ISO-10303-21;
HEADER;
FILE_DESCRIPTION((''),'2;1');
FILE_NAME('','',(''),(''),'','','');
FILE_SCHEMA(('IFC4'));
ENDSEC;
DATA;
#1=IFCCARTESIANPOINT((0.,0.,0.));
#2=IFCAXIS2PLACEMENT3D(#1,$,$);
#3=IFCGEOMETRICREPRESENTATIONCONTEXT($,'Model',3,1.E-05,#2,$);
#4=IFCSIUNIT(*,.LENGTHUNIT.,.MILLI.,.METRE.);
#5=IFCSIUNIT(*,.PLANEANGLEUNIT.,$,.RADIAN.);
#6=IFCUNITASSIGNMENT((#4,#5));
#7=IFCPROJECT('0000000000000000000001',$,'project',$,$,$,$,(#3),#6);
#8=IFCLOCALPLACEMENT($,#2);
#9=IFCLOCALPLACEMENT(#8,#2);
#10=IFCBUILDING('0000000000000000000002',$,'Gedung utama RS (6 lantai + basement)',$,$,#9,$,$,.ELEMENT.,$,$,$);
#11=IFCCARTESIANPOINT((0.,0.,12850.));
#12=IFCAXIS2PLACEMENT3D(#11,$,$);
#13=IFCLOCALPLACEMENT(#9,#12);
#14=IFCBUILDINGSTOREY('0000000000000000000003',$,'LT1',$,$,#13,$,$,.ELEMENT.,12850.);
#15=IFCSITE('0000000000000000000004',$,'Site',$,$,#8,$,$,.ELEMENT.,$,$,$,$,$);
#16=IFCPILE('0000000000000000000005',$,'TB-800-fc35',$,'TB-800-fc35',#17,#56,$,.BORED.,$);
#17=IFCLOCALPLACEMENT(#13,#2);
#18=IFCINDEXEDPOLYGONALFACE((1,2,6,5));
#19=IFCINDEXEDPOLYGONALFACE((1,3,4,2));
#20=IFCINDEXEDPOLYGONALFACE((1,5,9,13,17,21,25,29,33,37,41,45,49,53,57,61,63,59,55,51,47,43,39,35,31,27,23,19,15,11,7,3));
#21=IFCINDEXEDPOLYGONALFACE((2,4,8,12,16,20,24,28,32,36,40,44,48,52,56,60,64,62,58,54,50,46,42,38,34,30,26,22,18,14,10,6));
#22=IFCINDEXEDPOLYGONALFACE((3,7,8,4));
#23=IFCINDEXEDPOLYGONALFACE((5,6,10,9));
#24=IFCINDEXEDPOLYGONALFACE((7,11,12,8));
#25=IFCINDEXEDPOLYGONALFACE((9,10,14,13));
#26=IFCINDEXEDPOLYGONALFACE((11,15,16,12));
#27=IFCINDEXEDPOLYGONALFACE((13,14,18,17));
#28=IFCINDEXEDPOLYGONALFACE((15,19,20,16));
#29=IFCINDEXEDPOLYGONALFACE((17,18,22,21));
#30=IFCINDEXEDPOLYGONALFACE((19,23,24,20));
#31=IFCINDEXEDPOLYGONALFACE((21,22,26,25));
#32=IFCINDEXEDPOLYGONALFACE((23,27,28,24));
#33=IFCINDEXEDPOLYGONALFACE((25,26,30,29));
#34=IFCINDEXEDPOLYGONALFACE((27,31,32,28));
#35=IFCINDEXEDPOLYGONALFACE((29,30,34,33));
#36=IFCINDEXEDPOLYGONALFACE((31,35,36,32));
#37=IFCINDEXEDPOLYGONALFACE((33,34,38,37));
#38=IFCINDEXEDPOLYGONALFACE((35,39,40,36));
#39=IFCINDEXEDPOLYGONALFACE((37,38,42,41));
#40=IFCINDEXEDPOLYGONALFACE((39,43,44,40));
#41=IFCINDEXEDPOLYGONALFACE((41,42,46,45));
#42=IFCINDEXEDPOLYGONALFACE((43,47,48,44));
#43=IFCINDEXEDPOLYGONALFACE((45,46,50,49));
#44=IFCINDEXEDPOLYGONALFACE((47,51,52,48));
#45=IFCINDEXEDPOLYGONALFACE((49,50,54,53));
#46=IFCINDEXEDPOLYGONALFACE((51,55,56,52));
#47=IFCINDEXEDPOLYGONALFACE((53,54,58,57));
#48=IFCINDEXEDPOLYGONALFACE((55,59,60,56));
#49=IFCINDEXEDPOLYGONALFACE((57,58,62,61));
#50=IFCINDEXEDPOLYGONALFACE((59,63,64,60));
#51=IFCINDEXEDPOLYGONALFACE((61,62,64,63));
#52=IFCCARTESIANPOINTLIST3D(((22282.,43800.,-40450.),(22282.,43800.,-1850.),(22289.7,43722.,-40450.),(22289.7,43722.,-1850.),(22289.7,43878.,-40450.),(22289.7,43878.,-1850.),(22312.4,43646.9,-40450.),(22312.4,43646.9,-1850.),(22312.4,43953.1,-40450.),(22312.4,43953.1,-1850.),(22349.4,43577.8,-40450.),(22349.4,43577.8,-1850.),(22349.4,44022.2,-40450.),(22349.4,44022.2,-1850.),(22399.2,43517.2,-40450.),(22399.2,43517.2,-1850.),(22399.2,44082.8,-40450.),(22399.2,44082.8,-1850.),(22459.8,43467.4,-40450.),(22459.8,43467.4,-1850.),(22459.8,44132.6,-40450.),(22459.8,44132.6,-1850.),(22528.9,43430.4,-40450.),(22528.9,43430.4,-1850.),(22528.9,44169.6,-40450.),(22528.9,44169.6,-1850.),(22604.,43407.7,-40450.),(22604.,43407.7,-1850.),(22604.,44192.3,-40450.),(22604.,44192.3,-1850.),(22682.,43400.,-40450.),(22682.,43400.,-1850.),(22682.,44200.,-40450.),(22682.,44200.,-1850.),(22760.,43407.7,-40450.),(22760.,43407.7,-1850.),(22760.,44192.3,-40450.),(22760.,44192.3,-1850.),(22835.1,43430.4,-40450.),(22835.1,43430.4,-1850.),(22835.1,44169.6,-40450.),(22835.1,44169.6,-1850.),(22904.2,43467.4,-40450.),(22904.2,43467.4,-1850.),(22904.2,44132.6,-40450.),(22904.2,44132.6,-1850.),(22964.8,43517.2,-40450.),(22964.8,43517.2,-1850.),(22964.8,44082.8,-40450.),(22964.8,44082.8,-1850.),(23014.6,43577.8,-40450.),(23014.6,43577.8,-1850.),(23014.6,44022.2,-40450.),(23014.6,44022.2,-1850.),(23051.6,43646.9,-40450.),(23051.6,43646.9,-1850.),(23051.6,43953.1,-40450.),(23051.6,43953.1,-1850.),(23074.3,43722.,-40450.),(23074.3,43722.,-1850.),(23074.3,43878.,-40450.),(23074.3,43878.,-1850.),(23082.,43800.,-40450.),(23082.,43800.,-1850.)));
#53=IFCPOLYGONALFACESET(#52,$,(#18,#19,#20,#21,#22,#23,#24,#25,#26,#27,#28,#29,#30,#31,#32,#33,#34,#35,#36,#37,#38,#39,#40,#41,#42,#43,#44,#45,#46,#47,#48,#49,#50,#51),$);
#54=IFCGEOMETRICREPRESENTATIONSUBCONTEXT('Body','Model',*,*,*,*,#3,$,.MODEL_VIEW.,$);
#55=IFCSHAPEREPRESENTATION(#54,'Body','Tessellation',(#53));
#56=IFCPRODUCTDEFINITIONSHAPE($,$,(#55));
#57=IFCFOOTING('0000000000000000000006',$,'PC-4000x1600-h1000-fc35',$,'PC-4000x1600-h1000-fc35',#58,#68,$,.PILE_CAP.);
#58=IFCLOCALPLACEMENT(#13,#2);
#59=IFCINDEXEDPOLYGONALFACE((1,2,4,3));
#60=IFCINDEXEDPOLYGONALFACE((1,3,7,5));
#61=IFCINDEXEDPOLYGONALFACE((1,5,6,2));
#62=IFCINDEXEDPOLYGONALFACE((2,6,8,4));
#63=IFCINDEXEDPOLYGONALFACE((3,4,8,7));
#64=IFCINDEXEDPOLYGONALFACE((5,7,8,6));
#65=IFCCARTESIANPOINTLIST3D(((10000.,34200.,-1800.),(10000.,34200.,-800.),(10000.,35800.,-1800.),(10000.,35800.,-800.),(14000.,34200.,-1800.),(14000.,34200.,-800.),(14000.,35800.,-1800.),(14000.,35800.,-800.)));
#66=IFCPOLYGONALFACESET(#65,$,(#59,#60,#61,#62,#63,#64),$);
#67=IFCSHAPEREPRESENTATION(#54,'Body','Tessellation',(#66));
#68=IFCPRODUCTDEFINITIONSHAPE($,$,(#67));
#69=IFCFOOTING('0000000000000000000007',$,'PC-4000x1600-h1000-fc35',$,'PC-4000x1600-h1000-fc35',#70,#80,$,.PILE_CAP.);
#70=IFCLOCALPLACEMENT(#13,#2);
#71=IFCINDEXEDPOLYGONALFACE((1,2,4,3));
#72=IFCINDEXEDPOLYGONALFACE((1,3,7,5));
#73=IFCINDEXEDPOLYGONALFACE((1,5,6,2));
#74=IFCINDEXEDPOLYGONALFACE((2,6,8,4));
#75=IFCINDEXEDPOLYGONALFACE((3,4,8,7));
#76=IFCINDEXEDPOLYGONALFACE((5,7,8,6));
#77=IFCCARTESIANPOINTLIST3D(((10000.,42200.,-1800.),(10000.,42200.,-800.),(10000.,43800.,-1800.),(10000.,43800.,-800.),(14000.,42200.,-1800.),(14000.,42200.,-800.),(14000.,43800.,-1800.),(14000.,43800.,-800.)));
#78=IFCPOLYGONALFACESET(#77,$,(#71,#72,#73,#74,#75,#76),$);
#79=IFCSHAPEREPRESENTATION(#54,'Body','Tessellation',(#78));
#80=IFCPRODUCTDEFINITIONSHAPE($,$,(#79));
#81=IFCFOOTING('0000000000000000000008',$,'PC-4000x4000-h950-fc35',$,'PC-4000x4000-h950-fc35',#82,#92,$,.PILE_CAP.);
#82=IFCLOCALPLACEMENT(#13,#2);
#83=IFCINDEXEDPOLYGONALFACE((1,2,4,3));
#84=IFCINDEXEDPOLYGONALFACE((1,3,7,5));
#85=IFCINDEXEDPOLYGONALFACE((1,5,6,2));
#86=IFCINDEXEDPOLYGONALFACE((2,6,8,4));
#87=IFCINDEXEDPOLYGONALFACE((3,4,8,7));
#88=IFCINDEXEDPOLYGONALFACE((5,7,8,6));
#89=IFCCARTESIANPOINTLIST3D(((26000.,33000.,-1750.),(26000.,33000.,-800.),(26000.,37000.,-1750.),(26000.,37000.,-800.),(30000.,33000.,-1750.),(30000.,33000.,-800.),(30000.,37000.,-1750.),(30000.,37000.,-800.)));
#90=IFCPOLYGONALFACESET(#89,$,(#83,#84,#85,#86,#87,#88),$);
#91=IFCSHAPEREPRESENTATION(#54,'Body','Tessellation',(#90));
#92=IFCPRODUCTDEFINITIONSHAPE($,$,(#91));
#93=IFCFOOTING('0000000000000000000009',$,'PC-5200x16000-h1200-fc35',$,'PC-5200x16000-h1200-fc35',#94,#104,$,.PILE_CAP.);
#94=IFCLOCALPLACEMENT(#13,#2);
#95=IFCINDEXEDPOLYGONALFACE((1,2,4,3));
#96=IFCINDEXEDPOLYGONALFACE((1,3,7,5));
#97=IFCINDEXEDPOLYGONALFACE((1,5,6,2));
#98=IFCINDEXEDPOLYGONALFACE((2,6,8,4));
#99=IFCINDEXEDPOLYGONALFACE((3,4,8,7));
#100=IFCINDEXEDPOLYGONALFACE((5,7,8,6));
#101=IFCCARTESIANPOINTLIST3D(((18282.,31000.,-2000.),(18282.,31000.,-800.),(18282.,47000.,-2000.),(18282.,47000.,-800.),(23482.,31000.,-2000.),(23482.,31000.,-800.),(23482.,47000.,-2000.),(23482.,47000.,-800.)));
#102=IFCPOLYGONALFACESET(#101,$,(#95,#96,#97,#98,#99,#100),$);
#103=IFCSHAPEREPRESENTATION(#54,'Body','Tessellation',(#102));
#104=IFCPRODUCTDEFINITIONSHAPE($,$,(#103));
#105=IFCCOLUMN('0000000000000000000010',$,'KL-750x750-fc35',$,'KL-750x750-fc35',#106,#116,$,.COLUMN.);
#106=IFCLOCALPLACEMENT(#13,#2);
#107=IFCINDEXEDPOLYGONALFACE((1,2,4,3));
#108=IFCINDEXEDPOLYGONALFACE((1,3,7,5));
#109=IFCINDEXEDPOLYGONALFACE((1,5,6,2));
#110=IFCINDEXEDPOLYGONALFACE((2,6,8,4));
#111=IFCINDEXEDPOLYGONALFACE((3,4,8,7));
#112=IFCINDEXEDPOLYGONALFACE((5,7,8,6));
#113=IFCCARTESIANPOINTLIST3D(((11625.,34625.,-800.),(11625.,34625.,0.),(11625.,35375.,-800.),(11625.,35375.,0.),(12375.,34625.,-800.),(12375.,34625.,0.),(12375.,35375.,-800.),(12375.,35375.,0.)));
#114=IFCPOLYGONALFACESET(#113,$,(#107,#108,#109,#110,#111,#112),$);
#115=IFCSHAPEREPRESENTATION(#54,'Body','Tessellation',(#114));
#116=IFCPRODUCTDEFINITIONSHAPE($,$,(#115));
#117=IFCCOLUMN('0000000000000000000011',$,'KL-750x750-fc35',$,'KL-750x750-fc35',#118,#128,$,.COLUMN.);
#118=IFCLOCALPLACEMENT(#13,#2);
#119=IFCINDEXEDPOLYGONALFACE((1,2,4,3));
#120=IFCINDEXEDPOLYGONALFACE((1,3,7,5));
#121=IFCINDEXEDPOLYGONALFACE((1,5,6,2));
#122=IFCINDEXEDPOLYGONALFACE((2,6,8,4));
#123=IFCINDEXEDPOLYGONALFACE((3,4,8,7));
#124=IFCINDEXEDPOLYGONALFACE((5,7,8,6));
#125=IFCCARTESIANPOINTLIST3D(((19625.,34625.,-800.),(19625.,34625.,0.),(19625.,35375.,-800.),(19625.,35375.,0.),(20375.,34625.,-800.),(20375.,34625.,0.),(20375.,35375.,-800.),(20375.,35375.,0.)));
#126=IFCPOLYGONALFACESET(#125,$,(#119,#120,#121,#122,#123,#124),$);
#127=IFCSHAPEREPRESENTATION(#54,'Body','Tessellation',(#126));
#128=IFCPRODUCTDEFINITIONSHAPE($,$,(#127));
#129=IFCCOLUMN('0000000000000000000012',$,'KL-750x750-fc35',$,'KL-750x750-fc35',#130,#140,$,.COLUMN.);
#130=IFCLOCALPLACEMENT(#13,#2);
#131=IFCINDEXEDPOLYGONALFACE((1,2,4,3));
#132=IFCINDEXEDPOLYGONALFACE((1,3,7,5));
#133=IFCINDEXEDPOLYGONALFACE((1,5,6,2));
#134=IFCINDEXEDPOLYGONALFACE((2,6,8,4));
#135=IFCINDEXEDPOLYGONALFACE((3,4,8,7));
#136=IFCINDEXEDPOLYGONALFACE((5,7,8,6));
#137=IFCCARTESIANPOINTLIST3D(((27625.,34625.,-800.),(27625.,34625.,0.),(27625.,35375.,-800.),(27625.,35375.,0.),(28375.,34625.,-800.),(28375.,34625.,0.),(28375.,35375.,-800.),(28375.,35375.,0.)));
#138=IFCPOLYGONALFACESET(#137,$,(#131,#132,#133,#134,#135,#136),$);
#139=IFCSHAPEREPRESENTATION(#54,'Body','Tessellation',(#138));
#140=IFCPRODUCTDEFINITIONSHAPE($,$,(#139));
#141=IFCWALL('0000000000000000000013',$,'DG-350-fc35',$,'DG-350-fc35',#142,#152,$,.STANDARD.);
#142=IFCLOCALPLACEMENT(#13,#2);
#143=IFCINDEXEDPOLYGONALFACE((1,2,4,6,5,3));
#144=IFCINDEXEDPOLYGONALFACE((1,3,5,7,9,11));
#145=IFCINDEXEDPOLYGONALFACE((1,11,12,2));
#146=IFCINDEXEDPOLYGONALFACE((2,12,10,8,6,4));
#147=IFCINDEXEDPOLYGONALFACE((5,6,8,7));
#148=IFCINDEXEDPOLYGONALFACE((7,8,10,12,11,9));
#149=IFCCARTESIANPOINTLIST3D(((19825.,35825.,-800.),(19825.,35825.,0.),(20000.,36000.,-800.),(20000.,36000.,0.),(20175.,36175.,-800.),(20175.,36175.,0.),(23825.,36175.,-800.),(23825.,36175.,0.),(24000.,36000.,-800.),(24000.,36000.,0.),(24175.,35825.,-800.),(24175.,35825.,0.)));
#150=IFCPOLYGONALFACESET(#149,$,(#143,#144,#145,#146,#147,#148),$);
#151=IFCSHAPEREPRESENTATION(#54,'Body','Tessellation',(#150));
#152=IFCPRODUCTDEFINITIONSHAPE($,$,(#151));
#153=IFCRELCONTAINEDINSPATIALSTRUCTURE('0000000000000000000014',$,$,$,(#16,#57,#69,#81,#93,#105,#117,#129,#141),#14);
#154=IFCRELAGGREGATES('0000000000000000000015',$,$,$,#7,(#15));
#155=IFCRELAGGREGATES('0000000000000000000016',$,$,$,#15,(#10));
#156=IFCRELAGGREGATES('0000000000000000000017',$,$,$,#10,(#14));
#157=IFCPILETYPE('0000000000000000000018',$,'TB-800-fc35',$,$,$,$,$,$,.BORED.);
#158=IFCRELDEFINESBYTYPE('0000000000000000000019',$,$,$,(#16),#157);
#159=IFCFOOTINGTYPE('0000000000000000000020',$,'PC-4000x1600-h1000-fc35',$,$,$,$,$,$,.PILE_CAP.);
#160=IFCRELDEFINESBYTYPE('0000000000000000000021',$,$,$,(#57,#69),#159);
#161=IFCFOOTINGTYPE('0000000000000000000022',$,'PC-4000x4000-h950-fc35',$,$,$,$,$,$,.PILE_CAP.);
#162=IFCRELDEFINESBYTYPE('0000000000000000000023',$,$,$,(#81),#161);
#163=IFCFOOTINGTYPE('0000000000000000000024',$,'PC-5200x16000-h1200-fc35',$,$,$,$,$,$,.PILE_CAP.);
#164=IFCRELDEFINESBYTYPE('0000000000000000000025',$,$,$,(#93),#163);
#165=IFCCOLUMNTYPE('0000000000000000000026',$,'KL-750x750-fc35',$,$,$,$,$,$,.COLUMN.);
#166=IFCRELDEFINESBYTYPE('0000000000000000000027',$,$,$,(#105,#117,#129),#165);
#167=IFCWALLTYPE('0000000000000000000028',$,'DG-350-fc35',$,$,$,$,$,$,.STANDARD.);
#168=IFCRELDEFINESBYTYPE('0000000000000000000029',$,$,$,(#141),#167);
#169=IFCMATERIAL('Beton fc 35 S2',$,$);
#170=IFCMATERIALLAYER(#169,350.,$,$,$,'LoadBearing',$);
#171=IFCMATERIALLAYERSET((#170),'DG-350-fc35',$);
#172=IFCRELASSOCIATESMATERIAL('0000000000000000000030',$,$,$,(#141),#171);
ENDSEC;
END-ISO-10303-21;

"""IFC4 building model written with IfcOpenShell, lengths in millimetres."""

from ifc_helpers import new_model, si_unit, frame, origin, origin_2d, place, context, subcontext, project, spatial, polyline, rectangle, circle, outline, extrude, material, layer, layer_set, layer_usage, material_profile, profile_set, profile_usage, type_object, element, save


model = new_model("IFC4")

# Units and contexts
model_context = context("Model", 3, precision=1e-05, world=origin())
body_context = subcontext(model_context, "Body", "Model", "MODEL_VIEW")
ifc_project = project(units=[si_unit("LENGTHUNIT", "METRE", prefix="MILLI"), si_unit("PLANEANGLEUNIT", "RADIAN")], contexts=[model_context])

# Site, building, storey
site_placement = place(None, origin())
site = spatial("IfcSite", under=ifc_project, at=site_placement, Name="Site", CompositionType="ELEMENT")
building_placement = place(site_placement, origin())
building = spatial("IfcBuilding", under=site, at=building_placement, Name="Gedung utama RS (6 lantai + basement)", CompositionType="ELEMENT")
storey_placement = place(building_placement, frame((0.0, 0.0, 12850.0)))
storey = spatial("IfcBuildingStorey", under=building, at=storey_placement, Name="LT1", CompositionType="ELEMENT", Elevation=12850.0)

# Pile
ifc_material_profile_1 = material_profile(None, circle(Radius=400.0, at=origin_2d()), Name="TB-800-fc35")
ifc_profile_set_1 = profile_set([ifc_material_profile_1], Name="TB-800-fc35")
ifc_profile_usage_1 = profile_usage(ifc_profile_set_1, cardinal=5)
pile_type = type_object("IfcPileType", Name="TB-800-fc35", PredefinedType="BORED", material=ifc_profile_set_1)
for number, where, z_axis, x_axis, name in (
    (1, (22682.0, 43800.0, -40450.0), (0.0, 0.0, 1.0), (1.0, 0.0, 0.0), "TB-800-fc35"),
):
    element("IfcPile", number, at=place(storey_placement, frame(where, z_axis=z_axis, x_axis=x_axis)), inside=storey, type_object=pile_type, material=ifc_profile_usage_1, Name=name, ObjectType="TB-800-fc35", PredefinedType="BORED", context=body_context, shape_type="SweptSolid", body=[
        extrude(circle(Radius=400.0, at=origin_2d()), origin(), (0.0, 0.0, 1.0), 38600.0),
    ])

# Footings
ifc_material_profile_2 = material_profile(None, rectangle(XDim=4000.0, YDim=1600.0, at=origin_2d()), Name="PC-4000x1600-h1000-fc35")
ifc_profile_set_2 = profile_set([ifc_material_profile_2], Name="PC-4000x1600-h1000-fc35")
ifc_profile_usage_2 = profile_usage(ifc_profile_set_2, cardinal=5)
footing_type_1 = type_object("IfcFootingType", Name="PC-4000x1600-h1000-fc35", PredefinedType="PILE_CAP", material=ifc_profile_set_2)
for number, where, z_axis, x_axis, name in (
    (2, (12000.0, 35000.0, -1800.0), (0.0, 0.0, 1.0), (1.0, 0.0, 0.0), "PC-4000x1600-h1000-fc35"),
    (3, (12000.0, 43000.0, -1800.0), (0.0, 0.0, 1.0), (1.0, 0.0, 0.0), "PC-4000x1600-h1000-fc35"),
):
    element("IfcFooting", number, at=place(storey_placement, frame(where, z_axis=z_axis, x_axis=x_axis)), inside=storey, type_object=footing_type_1, material=ifc_profile_usage_2, Name=name, ObjectType="PC-4000x1600-h1000-fc35", PredefinedType="PILE_CAP", context=body_context, shape_type="SweptSolid", body=[
        extrude(rectangle(XDim=4000.0, YDim=1600.0, at=origin_2d()), origin(), (0.0, 0.0, 1.0), 1000.0),
    ])
ifc_material_profile_3 = material_profile(None, rectangle(XDim=4000.0, YDim=4000.0, at=origin_2d()), Name="PC-4000x4000-h950-fc35")
ifc_profile_set_3 = profile_set([ifc_material_profile_3], Name="PC-4000x4000-h950-fc35")
ifc_profile_usage_3 = profile_usage(ifc_profile_set_3, cardinal=5)
footing_type_2 = type_object("IfcFootingType", Name="PC-4000x4000-h950-fc35", PredefinedType="PILE_CAP", material=ifc_profile_set_3)
footing_1_placement = place(storey_placement, frame((28000.0, 35000.0, -1750.0), z_axis=(0.0, 0.0, 1.0), x_axis=(1.0, 0.0, 0.0)))
element("IfcFooting", 4, at=footing_1_placement, inside=storey, type_object=footing_type_2, material=ifc_profile_usage_3, Name="PC-4000x4000-h950-fc35", ObjectType="PC-4000x4000-h950-fc35", PredefinedType="PILE_CAP", context=body_context, shape_type="SweptSolid", body=[
    extrude(rectangle(XDim=4000.0, YDim=4000.0, at=origin_2d()), origin(), (0.0, 0.0, 1.0), 950.0),
])
ifc_material_profile_4 = material_profile(None, rectangle(XDim=5200.0, YDim=16000.0, at=origin_2d()), Name="PC-5200x16000-h1200-fc35")
ifc_profile_set_4 = profile_set([ifc_material_profile_4], Name="PC-5200x16000-h1200-fc35")
ifc_profile_usage_4 = profile_usage(ifc_profile_set_4, cardinal=5)
footing_type_3 = type_object("IfcFootingType", Name="PC-5200x16000-h1200-fc35", PredefinedType="PILE_CAP", material=ifc_profile_set_4)
footing_2_placement = place(storey_placement, frame((20882.0, 39000.0, -2000.0), z_axis=(0.0, 0.0, 1.0), x_axis=(1.0, 0.0, 0.0)))
element("IfcFooting", 5, at=footing_2_placement, inside=storey, type_object=footing_type_3, material=ifc_profile_usage_4, Name="PC-5200x16000-h1200-fc35", ObjectType="PC-5200x16000-h1200-fc35", PredefinedType="PILE_CAP", context=body_context, shape_type="SweptSolid", body=[
    extrude(rectangle(XDim=5200.0, YDim=16000.0, at=origin_2d()), origin(), (0.0, 0.0, 1.0), 1200.0),
])

# Columns
ifc_material_profile_5 = material_profile(None, rectangle(XDim=750.0, YDim=750.0, at=origin_2d()), Name="KL-750x750-fc35")
ifc_profile_set_5 = profile_set([ifc_material_profile_5], Name="KL-750x750-fc35")
ifc_profile_usage_5 = profile_usage(ifc_profile_set_5, cardinal=5)
column_type = type_object("IfcColumnType", Name="KL-750x750-fc35", PredefinedType="COLUMN", material=ifc_profile_set_5)
for number, where, z_axis, x_axis, name in (
    (6, (12000.0, 35000.0, -800.0), (0.0, 0.0, 1.0), (1.0, 0.0, 0.0), "KL-750x750-fc35"),
    (7, (20000.0, 35000.0, -800.0), (0.0, 0.0, 1.0), (1.0, 0.0, 0.0), "KL-750x750-fc35"),
    (8, (28000.0, 35000.0, -800.0), (0.0, 0.0, 1.0), (1.0, 0.0, 0.0), "KL-750x750-fc35"),
):
    element("IfcColumn", number, at=place(storey_placement, frame(where, z_axis=z_axis, x_axis=x_axis)), inside=storey, type_object=column_type, material=ifc_profile_usage_5, Name=name, ObjectType="KL-750x750-fc35", PredefinedType="COLUMN", context=body_context, shape_type="SweptSolid", body=[
        extrude(rectangle(XDim=750.0, YDim=750.0, at=origin_2d()), origin(), (0.0, 0.0, 1.0), 800.0),
    ])

# Wall
ifc_material = material(Name="Beton fc 35 S2")
ifc_layer = layer(ifc_material, 350.0, Category="LoadBearing")
ifc_layer_set = layer_set([ifc_layer], Name="DG-350-fc35")
ifc_layer_usage = layer_usage(ifc_layer_set, "AXIS2", "NEGATIVE", 175.0)
wall_type = type_object("IfcWallType", Name="DG-350-fc35", PredefinedType="STANDARD")
wall_placement = place(storey_placement, frame((20000.0, 36000.0, -800.0), z_axis=(0.0, 0.0, 1.0), x_axis=(1.0, 0.0, 0.0)))
element("IfcWall", 9, at=wall_placement, inside=storey, type_object=wall_type, material=ifc_layer_usage, Name="DG-350-fc35", ObjectType="DG-350-fc35", PredefinedType="STANDARD", context=body_context, shape_type="SweptSolid", body=[
    extrude(outline(polyline([(-175.0, -175.0), (0.0, 0.0), (175.0, 175.0), (3825.0, 175.0), (4000.0, 0.0), (4175.0, -175.0), (-175.0, -175.0)])), origin(), (0.0, 0.0, 1.0), 800.0),
])

save(model, "model.ifc")
